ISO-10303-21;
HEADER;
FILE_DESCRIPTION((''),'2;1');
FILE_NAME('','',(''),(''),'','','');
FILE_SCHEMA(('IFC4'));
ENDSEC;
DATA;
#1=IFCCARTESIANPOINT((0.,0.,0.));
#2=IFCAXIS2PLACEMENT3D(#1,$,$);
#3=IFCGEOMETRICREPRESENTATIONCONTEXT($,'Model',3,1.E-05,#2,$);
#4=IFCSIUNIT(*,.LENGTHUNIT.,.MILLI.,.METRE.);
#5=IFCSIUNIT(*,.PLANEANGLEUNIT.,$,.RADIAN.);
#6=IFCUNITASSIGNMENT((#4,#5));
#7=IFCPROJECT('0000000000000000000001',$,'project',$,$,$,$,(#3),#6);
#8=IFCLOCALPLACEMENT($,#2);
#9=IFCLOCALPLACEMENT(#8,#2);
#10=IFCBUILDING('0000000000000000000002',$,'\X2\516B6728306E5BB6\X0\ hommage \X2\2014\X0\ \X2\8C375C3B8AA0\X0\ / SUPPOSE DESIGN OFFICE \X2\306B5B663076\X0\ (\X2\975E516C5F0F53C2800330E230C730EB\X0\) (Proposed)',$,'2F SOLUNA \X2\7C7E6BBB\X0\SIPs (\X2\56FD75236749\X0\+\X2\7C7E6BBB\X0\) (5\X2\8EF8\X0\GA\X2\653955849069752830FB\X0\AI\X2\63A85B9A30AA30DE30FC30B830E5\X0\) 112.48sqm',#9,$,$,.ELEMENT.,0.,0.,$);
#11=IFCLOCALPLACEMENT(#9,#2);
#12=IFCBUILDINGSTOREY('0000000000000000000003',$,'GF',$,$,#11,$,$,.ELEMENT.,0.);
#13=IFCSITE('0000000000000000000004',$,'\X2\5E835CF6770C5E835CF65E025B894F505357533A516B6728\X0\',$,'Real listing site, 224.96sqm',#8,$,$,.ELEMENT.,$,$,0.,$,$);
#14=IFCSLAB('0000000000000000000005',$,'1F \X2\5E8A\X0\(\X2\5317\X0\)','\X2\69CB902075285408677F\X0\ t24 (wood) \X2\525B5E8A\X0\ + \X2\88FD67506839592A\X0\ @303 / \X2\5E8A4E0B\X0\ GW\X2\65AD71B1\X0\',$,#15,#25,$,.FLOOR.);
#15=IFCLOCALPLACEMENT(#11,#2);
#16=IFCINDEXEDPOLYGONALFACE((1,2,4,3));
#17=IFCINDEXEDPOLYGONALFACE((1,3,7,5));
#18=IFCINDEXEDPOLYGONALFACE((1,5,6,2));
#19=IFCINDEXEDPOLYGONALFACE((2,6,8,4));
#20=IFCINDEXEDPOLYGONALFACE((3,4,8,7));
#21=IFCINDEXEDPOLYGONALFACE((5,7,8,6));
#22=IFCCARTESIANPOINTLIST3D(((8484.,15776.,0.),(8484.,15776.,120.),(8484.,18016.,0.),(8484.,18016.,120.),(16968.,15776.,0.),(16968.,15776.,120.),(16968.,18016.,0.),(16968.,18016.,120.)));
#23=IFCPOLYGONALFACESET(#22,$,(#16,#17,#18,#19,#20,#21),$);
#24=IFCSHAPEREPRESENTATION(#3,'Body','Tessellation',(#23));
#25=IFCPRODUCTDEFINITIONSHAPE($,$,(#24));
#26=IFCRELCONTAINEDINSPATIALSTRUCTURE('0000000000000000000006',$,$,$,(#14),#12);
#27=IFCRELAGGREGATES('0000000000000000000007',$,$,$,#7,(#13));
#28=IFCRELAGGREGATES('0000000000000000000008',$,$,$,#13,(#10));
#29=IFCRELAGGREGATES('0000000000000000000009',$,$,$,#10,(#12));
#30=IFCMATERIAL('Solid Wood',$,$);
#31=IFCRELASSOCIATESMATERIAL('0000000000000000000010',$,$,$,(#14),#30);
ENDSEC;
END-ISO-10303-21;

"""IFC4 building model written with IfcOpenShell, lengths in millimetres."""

from ifc_helpers import new_model, si_unit, frame, frame_2d, origin, place, context, project, spatial, rectangle, extrude, material, element, save


model = new_model("IFC4")

# Units and contexts
model_context = context("Model", 3, precision=1e-05, world=origin())
ifc_project = project(units=[si_unit("LENGTHUNIT", "METRE", prefix="MILLI"), si_unit("PLANEANGLEUNIT", "RADIAN")], contexts=[model_context])

# Site, building, storey
site_placement = place(None, origin())
site = spatial("IfcSite", under=ifc_project, at=site_placement, Name="広島県広島市安佐南区八木", ObjectType="Real listing site, 224.96sqm", CompositionType="ELEMENT", RefElevation=0.0)
building_placement = place(site_placement, origin())
building = spatial("IfcBuilding", under=site, at=building_placement, Name="八木の家 hommage — 谷尻誠 / SUPPOSE DESIGN OFFICE に学ぶ (非公式参考モデル) (Proposed)", ObjectType="2F SOLUNA 籾殻SIPs (国産杉+籾殻) (5軸GA改善適用・AI推定オマージュ) 112.48sqm", CompositionType="ELEMENT", ElevationOfRefHeight=0.0, ElevationOfTerrain=0.0)
storey_placement = place(building_placement, origin())
storey = spatial("IfcBuildingStorey", under=building, at=storey_placement, Name="GF", CompositionType="ELEMENT", Elevation=0.0)

# Slab
ifc_material_1 = material(Name="Solid Wood")
slab_1_placement = place(storey_placement, frame((4242.0, 7888.0, 0.0)))
element("IfcSlab", 1, at=slab_1_placement, inside=storey, material=ifc_material_1, Name="1F 床(北)", Description="構造用合板 t24 (wood) 剛床 + 製材根太 @303 / 床下 GW断熱", PredefinedType="FLOOR", context=model_context, shape_type="SweptSolid", body=[
    extrude(rectangle(XDim=8484.0, YDim=2240.0, at=frame_2d((4242.0, 1120.0))), frame((4242.0, 7888.0, 0.0)), (0.0, 0.0, 1.0), 120.0),
])

save(model, "model.ifc")
